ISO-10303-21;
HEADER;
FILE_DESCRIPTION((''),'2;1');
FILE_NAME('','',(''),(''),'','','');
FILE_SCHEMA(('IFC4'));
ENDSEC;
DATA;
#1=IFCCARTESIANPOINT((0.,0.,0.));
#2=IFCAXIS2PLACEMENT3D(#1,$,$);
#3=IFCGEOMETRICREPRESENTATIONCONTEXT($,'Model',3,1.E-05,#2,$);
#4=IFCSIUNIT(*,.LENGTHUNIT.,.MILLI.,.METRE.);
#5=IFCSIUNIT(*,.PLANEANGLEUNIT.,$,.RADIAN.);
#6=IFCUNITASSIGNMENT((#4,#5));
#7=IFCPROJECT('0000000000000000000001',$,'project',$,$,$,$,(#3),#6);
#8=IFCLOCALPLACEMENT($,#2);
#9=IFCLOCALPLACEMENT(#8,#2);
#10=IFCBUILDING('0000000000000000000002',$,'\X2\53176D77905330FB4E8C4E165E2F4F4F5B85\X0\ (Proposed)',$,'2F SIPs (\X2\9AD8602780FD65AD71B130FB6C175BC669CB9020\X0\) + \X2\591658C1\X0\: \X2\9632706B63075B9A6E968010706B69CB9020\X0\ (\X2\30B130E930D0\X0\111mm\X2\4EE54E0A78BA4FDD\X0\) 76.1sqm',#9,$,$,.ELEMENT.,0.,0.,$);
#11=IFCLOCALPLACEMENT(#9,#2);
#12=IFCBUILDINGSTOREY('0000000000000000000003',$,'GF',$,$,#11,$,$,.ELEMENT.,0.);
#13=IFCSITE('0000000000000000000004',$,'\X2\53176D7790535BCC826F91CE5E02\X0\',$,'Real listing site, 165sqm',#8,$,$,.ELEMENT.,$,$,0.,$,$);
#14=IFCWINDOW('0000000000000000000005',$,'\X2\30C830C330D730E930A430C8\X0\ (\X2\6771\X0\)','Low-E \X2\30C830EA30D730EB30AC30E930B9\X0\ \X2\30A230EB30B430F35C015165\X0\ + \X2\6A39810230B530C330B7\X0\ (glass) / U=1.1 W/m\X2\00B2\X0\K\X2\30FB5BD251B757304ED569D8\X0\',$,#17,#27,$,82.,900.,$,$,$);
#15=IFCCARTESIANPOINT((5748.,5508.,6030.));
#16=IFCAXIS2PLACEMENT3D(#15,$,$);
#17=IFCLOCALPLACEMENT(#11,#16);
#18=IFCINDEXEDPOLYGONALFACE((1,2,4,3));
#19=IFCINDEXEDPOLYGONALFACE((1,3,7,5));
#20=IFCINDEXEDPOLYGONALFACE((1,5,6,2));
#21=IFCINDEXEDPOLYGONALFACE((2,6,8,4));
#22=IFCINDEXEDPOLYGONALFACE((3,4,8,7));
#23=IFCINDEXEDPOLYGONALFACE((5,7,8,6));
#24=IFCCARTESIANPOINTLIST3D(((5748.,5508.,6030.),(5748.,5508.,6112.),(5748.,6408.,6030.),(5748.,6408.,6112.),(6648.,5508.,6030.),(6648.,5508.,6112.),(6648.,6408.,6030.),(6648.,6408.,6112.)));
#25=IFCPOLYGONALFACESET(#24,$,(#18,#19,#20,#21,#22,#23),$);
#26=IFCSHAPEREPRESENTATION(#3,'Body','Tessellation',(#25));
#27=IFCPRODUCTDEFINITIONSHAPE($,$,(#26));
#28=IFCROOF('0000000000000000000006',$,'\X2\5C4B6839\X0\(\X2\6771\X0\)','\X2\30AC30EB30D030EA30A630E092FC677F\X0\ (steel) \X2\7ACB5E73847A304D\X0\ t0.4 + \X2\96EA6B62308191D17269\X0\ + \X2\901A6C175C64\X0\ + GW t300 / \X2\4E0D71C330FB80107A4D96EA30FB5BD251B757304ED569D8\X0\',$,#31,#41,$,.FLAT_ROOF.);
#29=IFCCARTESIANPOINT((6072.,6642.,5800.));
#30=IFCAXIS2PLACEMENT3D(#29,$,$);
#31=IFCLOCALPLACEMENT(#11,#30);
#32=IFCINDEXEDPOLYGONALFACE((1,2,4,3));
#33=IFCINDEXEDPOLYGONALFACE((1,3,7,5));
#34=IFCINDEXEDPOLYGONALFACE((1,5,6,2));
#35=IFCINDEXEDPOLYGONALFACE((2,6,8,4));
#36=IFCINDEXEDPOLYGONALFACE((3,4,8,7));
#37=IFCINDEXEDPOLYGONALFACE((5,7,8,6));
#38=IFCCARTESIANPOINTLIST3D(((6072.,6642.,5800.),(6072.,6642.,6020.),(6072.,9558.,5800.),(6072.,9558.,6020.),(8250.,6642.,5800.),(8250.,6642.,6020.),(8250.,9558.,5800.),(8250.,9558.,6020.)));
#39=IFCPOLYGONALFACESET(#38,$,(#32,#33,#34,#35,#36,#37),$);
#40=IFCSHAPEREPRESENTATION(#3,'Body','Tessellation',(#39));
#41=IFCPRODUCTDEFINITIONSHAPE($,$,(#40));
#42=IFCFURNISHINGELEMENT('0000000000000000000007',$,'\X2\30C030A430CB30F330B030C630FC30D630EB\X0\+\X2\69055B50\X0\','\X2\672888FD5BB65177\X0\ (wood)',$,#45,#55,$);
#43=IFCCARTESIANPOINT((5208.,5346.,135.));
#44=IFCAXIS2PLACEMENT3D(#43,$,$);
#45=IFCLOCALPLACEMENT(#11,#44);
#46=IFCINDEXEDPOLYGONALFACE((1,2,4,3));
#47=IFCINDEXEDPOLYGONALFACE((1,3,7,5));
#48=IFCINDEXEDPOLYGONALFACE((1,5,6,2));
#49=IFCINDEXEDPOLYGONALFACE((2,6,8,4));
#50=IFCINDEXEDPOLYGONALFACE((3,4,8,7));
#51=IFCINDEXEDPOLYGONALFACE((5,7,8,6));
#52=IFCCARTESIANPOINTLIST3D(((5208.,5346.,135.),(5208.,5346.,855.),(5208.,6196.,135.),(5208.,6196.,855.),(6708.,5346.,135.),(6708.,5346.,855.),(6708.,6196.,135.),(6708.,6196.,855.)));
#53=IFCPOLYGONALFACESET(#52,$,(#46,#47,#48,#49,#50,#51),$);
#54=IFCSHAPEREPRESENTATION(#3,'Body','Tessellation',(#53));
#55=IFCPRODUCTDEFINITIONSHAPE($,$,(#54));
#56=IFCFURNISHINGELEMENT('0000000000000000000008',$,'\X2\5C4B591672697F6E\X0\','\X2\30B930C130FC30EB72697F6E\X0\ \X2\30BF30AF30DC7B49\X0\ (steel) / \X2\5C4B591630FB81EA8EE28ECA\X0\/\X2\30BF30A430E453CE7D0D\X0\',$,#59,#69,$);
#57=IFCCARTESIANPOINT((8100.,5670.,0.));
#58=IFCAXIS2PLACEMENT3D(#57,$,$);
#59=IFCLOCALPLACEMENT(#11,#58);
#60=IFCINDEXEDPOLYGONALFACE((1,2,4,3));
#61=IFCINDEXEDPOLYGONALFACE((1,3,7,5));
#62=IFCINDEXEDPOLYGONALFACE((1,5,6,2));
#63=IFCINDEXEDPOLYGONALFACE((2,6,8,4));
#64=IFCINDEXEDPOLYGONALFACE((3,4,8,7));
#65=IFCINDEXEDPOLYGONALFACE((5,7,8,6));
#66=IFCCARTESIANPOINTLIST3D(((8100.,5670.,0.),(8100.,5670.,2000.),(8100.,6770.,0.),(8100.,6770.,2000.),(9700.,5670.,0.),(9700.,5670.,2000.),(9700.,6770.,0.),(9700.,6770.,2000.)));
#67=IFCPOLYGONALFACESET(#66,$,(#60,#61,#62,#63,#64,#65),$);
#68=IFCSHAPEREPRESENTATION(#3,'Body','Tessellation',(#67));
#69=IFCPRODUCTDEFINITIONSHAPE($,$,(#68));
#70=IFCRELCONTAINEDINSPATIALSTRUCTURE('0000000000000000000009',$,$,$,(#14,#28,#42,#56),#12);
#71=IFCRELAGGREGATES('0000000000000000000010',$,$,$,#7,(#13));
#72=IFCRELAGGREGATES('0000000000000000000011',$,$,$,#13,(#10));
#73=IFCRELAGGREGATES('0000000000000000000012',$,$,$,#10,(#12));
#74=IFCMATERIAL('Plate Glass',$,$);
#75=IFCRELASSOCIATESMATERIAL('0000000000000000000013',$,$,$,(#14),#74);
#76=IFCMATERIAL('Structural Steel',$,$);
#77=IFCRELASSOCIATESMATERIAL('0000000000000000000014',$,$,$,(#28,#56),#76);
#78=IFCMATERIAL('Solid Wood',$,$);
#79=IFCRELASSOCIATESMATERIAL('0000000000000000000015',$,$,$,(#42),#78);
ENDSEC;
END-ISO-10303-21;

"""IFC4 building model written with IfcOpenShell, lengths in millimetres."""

from ifc_helpers import new_model, si_unit, frame, frame_2d, origin, place, context, project, spatial, rectangle, extrude, material, element, save


model = new_model("IFC4")

# Units and contexts
model_context = context("Model", 3, precision=1e-05, world=origin())
ifc_project = project(units=[si_unit("LENGTHUNIT", "METRE", prefix="MILLI"), si_unit("PLANEANGLEUNIT", "RADIAN")], contexts=[model_context])

# Site, building, storey
site_placement = place(None, origin())
site = spatial("IfcSite", under=ifc_project, at=site_placement, Name="北海道富良野市", ObjectType="Real listing site, 165sqm", CompositionType="ELEMENT", RefElevation=0.0)
building_placement = place(site_placement, origin())
building = spatial("IfcBuilding", under=site, at=building_placement, Name="北海道・二世帯住宅 (Proposed)", ObjectType="2F SIPs (高性能断熱・気密構造) + 外壁: 防火指定準耐火構造 (ケラバ111mm以上確保) 76.1sqm", CompositionType="ELEMENT", ElevationOfRefHeight=0.0, ElevationOfTerrain=0.0)
storey_placement = place(building_placement, origin())
storey = spatial("IfcBuildingStorey", under=building, at=storey_placement, Name="GF", CompositionType="ELEMENT", Elevation=0.0)

# Shared definitions
ifc_material_1 = material(Name="Solid Wood")

# Shared definitions
ifc_material_2 = material(Name="Plate Glass")

# Window
window_1_placement = place(storey_placement, frame((5748.0, 5508.0, 6030.0)))
element("IfcWindow", 1, at=window_1_placement, inside=storey, material=ifc_material_2, Name="トップライト (東)", Description="Low-E トリプルガラス アルゴン封入 + 樹脂サッシ (glass) / U=1.1 W/m²K・寒冷地仕様", OverallHeight=82.0, OverallWidth=900.0, context=model_context, shape_type="SweptSolid", body=[
    extrude(rectangle(XDim=900.0, YDim=900.0, at=frame_2d((450.0, 450.0))), frame((5748.0, 5508.0, 6030.0)), (0.0, 0.0, 1.0), 82.0),
])

# Roof
ifc_material_3 = material(Name="Structural Steel")
for number, where, name in (
    (2, (6072.0, 6642.0, 5800.0), "屋根(東)"),
):
    element("IfcRoof", number, at=place(storey_placement, frame(where)), inside=storey, material=ifc_material_3, Name=name, Description="ガルバリウム鋼板 (steel) 立平葺き t0.4 + 雪止め金物 + 通気層 + GW t300 / 不燃・耐積雪・寒冷地仕様", PredefinedType="FLAT_ROOF", context=model_context, shape_type="SweptSolid", body=[
        extrude(rectangle(XDim=2178.0, YDim=2916.0, at=frame_2d((1089.0, 1458.0))), frame((6072.0, 6642.0, 5800.0)), (0.0, 0.0, 1.0), 220.0),
    ])

# Furnishing elements
furnishing_1_placement = place(storey_placement, frame((5208.0, 5346.0, 135.0)))
element("IfcFurnishingElement", 3, at=furnishing_1_placement, inside=storey, material=ifc_material_1, Name="ダイニングテーブル+椅子", Description="木製家具 (wood)", context=model_context, shape_type="SweptSolid", body=[
    extrude(rectangle(XDim=1500.0, YDim=850.0, at=frame_2d((750.0, 425.0))), frame((5208.0, 5346.0, 135.0)), (0.0, 0.0, 1.0), 720.0),
])
furnishing_2_placement = place(storey_placement, frame((8100.0, 5670.0, 0.0)))
element("IfcFurnishingElement", 4, at=furnishing_2_placement, inside=storey, material=ifc_material_3, Name="屋外物置", Description="スチール物置 タクボ等 (steel) / 屋外・自転車/タイヤ収納", context=model_context, shape_type="SweptSolid", body=[
    extrude(rectangle(XDim=1600.0, YDim=1100.0, at=frame_2d((800.0, 550.0))), frame((8100.0, 5670.0, 0.0)), (0.0, 0.0, 1.0), 2000.0),
])

save(model, "model.ifc")
